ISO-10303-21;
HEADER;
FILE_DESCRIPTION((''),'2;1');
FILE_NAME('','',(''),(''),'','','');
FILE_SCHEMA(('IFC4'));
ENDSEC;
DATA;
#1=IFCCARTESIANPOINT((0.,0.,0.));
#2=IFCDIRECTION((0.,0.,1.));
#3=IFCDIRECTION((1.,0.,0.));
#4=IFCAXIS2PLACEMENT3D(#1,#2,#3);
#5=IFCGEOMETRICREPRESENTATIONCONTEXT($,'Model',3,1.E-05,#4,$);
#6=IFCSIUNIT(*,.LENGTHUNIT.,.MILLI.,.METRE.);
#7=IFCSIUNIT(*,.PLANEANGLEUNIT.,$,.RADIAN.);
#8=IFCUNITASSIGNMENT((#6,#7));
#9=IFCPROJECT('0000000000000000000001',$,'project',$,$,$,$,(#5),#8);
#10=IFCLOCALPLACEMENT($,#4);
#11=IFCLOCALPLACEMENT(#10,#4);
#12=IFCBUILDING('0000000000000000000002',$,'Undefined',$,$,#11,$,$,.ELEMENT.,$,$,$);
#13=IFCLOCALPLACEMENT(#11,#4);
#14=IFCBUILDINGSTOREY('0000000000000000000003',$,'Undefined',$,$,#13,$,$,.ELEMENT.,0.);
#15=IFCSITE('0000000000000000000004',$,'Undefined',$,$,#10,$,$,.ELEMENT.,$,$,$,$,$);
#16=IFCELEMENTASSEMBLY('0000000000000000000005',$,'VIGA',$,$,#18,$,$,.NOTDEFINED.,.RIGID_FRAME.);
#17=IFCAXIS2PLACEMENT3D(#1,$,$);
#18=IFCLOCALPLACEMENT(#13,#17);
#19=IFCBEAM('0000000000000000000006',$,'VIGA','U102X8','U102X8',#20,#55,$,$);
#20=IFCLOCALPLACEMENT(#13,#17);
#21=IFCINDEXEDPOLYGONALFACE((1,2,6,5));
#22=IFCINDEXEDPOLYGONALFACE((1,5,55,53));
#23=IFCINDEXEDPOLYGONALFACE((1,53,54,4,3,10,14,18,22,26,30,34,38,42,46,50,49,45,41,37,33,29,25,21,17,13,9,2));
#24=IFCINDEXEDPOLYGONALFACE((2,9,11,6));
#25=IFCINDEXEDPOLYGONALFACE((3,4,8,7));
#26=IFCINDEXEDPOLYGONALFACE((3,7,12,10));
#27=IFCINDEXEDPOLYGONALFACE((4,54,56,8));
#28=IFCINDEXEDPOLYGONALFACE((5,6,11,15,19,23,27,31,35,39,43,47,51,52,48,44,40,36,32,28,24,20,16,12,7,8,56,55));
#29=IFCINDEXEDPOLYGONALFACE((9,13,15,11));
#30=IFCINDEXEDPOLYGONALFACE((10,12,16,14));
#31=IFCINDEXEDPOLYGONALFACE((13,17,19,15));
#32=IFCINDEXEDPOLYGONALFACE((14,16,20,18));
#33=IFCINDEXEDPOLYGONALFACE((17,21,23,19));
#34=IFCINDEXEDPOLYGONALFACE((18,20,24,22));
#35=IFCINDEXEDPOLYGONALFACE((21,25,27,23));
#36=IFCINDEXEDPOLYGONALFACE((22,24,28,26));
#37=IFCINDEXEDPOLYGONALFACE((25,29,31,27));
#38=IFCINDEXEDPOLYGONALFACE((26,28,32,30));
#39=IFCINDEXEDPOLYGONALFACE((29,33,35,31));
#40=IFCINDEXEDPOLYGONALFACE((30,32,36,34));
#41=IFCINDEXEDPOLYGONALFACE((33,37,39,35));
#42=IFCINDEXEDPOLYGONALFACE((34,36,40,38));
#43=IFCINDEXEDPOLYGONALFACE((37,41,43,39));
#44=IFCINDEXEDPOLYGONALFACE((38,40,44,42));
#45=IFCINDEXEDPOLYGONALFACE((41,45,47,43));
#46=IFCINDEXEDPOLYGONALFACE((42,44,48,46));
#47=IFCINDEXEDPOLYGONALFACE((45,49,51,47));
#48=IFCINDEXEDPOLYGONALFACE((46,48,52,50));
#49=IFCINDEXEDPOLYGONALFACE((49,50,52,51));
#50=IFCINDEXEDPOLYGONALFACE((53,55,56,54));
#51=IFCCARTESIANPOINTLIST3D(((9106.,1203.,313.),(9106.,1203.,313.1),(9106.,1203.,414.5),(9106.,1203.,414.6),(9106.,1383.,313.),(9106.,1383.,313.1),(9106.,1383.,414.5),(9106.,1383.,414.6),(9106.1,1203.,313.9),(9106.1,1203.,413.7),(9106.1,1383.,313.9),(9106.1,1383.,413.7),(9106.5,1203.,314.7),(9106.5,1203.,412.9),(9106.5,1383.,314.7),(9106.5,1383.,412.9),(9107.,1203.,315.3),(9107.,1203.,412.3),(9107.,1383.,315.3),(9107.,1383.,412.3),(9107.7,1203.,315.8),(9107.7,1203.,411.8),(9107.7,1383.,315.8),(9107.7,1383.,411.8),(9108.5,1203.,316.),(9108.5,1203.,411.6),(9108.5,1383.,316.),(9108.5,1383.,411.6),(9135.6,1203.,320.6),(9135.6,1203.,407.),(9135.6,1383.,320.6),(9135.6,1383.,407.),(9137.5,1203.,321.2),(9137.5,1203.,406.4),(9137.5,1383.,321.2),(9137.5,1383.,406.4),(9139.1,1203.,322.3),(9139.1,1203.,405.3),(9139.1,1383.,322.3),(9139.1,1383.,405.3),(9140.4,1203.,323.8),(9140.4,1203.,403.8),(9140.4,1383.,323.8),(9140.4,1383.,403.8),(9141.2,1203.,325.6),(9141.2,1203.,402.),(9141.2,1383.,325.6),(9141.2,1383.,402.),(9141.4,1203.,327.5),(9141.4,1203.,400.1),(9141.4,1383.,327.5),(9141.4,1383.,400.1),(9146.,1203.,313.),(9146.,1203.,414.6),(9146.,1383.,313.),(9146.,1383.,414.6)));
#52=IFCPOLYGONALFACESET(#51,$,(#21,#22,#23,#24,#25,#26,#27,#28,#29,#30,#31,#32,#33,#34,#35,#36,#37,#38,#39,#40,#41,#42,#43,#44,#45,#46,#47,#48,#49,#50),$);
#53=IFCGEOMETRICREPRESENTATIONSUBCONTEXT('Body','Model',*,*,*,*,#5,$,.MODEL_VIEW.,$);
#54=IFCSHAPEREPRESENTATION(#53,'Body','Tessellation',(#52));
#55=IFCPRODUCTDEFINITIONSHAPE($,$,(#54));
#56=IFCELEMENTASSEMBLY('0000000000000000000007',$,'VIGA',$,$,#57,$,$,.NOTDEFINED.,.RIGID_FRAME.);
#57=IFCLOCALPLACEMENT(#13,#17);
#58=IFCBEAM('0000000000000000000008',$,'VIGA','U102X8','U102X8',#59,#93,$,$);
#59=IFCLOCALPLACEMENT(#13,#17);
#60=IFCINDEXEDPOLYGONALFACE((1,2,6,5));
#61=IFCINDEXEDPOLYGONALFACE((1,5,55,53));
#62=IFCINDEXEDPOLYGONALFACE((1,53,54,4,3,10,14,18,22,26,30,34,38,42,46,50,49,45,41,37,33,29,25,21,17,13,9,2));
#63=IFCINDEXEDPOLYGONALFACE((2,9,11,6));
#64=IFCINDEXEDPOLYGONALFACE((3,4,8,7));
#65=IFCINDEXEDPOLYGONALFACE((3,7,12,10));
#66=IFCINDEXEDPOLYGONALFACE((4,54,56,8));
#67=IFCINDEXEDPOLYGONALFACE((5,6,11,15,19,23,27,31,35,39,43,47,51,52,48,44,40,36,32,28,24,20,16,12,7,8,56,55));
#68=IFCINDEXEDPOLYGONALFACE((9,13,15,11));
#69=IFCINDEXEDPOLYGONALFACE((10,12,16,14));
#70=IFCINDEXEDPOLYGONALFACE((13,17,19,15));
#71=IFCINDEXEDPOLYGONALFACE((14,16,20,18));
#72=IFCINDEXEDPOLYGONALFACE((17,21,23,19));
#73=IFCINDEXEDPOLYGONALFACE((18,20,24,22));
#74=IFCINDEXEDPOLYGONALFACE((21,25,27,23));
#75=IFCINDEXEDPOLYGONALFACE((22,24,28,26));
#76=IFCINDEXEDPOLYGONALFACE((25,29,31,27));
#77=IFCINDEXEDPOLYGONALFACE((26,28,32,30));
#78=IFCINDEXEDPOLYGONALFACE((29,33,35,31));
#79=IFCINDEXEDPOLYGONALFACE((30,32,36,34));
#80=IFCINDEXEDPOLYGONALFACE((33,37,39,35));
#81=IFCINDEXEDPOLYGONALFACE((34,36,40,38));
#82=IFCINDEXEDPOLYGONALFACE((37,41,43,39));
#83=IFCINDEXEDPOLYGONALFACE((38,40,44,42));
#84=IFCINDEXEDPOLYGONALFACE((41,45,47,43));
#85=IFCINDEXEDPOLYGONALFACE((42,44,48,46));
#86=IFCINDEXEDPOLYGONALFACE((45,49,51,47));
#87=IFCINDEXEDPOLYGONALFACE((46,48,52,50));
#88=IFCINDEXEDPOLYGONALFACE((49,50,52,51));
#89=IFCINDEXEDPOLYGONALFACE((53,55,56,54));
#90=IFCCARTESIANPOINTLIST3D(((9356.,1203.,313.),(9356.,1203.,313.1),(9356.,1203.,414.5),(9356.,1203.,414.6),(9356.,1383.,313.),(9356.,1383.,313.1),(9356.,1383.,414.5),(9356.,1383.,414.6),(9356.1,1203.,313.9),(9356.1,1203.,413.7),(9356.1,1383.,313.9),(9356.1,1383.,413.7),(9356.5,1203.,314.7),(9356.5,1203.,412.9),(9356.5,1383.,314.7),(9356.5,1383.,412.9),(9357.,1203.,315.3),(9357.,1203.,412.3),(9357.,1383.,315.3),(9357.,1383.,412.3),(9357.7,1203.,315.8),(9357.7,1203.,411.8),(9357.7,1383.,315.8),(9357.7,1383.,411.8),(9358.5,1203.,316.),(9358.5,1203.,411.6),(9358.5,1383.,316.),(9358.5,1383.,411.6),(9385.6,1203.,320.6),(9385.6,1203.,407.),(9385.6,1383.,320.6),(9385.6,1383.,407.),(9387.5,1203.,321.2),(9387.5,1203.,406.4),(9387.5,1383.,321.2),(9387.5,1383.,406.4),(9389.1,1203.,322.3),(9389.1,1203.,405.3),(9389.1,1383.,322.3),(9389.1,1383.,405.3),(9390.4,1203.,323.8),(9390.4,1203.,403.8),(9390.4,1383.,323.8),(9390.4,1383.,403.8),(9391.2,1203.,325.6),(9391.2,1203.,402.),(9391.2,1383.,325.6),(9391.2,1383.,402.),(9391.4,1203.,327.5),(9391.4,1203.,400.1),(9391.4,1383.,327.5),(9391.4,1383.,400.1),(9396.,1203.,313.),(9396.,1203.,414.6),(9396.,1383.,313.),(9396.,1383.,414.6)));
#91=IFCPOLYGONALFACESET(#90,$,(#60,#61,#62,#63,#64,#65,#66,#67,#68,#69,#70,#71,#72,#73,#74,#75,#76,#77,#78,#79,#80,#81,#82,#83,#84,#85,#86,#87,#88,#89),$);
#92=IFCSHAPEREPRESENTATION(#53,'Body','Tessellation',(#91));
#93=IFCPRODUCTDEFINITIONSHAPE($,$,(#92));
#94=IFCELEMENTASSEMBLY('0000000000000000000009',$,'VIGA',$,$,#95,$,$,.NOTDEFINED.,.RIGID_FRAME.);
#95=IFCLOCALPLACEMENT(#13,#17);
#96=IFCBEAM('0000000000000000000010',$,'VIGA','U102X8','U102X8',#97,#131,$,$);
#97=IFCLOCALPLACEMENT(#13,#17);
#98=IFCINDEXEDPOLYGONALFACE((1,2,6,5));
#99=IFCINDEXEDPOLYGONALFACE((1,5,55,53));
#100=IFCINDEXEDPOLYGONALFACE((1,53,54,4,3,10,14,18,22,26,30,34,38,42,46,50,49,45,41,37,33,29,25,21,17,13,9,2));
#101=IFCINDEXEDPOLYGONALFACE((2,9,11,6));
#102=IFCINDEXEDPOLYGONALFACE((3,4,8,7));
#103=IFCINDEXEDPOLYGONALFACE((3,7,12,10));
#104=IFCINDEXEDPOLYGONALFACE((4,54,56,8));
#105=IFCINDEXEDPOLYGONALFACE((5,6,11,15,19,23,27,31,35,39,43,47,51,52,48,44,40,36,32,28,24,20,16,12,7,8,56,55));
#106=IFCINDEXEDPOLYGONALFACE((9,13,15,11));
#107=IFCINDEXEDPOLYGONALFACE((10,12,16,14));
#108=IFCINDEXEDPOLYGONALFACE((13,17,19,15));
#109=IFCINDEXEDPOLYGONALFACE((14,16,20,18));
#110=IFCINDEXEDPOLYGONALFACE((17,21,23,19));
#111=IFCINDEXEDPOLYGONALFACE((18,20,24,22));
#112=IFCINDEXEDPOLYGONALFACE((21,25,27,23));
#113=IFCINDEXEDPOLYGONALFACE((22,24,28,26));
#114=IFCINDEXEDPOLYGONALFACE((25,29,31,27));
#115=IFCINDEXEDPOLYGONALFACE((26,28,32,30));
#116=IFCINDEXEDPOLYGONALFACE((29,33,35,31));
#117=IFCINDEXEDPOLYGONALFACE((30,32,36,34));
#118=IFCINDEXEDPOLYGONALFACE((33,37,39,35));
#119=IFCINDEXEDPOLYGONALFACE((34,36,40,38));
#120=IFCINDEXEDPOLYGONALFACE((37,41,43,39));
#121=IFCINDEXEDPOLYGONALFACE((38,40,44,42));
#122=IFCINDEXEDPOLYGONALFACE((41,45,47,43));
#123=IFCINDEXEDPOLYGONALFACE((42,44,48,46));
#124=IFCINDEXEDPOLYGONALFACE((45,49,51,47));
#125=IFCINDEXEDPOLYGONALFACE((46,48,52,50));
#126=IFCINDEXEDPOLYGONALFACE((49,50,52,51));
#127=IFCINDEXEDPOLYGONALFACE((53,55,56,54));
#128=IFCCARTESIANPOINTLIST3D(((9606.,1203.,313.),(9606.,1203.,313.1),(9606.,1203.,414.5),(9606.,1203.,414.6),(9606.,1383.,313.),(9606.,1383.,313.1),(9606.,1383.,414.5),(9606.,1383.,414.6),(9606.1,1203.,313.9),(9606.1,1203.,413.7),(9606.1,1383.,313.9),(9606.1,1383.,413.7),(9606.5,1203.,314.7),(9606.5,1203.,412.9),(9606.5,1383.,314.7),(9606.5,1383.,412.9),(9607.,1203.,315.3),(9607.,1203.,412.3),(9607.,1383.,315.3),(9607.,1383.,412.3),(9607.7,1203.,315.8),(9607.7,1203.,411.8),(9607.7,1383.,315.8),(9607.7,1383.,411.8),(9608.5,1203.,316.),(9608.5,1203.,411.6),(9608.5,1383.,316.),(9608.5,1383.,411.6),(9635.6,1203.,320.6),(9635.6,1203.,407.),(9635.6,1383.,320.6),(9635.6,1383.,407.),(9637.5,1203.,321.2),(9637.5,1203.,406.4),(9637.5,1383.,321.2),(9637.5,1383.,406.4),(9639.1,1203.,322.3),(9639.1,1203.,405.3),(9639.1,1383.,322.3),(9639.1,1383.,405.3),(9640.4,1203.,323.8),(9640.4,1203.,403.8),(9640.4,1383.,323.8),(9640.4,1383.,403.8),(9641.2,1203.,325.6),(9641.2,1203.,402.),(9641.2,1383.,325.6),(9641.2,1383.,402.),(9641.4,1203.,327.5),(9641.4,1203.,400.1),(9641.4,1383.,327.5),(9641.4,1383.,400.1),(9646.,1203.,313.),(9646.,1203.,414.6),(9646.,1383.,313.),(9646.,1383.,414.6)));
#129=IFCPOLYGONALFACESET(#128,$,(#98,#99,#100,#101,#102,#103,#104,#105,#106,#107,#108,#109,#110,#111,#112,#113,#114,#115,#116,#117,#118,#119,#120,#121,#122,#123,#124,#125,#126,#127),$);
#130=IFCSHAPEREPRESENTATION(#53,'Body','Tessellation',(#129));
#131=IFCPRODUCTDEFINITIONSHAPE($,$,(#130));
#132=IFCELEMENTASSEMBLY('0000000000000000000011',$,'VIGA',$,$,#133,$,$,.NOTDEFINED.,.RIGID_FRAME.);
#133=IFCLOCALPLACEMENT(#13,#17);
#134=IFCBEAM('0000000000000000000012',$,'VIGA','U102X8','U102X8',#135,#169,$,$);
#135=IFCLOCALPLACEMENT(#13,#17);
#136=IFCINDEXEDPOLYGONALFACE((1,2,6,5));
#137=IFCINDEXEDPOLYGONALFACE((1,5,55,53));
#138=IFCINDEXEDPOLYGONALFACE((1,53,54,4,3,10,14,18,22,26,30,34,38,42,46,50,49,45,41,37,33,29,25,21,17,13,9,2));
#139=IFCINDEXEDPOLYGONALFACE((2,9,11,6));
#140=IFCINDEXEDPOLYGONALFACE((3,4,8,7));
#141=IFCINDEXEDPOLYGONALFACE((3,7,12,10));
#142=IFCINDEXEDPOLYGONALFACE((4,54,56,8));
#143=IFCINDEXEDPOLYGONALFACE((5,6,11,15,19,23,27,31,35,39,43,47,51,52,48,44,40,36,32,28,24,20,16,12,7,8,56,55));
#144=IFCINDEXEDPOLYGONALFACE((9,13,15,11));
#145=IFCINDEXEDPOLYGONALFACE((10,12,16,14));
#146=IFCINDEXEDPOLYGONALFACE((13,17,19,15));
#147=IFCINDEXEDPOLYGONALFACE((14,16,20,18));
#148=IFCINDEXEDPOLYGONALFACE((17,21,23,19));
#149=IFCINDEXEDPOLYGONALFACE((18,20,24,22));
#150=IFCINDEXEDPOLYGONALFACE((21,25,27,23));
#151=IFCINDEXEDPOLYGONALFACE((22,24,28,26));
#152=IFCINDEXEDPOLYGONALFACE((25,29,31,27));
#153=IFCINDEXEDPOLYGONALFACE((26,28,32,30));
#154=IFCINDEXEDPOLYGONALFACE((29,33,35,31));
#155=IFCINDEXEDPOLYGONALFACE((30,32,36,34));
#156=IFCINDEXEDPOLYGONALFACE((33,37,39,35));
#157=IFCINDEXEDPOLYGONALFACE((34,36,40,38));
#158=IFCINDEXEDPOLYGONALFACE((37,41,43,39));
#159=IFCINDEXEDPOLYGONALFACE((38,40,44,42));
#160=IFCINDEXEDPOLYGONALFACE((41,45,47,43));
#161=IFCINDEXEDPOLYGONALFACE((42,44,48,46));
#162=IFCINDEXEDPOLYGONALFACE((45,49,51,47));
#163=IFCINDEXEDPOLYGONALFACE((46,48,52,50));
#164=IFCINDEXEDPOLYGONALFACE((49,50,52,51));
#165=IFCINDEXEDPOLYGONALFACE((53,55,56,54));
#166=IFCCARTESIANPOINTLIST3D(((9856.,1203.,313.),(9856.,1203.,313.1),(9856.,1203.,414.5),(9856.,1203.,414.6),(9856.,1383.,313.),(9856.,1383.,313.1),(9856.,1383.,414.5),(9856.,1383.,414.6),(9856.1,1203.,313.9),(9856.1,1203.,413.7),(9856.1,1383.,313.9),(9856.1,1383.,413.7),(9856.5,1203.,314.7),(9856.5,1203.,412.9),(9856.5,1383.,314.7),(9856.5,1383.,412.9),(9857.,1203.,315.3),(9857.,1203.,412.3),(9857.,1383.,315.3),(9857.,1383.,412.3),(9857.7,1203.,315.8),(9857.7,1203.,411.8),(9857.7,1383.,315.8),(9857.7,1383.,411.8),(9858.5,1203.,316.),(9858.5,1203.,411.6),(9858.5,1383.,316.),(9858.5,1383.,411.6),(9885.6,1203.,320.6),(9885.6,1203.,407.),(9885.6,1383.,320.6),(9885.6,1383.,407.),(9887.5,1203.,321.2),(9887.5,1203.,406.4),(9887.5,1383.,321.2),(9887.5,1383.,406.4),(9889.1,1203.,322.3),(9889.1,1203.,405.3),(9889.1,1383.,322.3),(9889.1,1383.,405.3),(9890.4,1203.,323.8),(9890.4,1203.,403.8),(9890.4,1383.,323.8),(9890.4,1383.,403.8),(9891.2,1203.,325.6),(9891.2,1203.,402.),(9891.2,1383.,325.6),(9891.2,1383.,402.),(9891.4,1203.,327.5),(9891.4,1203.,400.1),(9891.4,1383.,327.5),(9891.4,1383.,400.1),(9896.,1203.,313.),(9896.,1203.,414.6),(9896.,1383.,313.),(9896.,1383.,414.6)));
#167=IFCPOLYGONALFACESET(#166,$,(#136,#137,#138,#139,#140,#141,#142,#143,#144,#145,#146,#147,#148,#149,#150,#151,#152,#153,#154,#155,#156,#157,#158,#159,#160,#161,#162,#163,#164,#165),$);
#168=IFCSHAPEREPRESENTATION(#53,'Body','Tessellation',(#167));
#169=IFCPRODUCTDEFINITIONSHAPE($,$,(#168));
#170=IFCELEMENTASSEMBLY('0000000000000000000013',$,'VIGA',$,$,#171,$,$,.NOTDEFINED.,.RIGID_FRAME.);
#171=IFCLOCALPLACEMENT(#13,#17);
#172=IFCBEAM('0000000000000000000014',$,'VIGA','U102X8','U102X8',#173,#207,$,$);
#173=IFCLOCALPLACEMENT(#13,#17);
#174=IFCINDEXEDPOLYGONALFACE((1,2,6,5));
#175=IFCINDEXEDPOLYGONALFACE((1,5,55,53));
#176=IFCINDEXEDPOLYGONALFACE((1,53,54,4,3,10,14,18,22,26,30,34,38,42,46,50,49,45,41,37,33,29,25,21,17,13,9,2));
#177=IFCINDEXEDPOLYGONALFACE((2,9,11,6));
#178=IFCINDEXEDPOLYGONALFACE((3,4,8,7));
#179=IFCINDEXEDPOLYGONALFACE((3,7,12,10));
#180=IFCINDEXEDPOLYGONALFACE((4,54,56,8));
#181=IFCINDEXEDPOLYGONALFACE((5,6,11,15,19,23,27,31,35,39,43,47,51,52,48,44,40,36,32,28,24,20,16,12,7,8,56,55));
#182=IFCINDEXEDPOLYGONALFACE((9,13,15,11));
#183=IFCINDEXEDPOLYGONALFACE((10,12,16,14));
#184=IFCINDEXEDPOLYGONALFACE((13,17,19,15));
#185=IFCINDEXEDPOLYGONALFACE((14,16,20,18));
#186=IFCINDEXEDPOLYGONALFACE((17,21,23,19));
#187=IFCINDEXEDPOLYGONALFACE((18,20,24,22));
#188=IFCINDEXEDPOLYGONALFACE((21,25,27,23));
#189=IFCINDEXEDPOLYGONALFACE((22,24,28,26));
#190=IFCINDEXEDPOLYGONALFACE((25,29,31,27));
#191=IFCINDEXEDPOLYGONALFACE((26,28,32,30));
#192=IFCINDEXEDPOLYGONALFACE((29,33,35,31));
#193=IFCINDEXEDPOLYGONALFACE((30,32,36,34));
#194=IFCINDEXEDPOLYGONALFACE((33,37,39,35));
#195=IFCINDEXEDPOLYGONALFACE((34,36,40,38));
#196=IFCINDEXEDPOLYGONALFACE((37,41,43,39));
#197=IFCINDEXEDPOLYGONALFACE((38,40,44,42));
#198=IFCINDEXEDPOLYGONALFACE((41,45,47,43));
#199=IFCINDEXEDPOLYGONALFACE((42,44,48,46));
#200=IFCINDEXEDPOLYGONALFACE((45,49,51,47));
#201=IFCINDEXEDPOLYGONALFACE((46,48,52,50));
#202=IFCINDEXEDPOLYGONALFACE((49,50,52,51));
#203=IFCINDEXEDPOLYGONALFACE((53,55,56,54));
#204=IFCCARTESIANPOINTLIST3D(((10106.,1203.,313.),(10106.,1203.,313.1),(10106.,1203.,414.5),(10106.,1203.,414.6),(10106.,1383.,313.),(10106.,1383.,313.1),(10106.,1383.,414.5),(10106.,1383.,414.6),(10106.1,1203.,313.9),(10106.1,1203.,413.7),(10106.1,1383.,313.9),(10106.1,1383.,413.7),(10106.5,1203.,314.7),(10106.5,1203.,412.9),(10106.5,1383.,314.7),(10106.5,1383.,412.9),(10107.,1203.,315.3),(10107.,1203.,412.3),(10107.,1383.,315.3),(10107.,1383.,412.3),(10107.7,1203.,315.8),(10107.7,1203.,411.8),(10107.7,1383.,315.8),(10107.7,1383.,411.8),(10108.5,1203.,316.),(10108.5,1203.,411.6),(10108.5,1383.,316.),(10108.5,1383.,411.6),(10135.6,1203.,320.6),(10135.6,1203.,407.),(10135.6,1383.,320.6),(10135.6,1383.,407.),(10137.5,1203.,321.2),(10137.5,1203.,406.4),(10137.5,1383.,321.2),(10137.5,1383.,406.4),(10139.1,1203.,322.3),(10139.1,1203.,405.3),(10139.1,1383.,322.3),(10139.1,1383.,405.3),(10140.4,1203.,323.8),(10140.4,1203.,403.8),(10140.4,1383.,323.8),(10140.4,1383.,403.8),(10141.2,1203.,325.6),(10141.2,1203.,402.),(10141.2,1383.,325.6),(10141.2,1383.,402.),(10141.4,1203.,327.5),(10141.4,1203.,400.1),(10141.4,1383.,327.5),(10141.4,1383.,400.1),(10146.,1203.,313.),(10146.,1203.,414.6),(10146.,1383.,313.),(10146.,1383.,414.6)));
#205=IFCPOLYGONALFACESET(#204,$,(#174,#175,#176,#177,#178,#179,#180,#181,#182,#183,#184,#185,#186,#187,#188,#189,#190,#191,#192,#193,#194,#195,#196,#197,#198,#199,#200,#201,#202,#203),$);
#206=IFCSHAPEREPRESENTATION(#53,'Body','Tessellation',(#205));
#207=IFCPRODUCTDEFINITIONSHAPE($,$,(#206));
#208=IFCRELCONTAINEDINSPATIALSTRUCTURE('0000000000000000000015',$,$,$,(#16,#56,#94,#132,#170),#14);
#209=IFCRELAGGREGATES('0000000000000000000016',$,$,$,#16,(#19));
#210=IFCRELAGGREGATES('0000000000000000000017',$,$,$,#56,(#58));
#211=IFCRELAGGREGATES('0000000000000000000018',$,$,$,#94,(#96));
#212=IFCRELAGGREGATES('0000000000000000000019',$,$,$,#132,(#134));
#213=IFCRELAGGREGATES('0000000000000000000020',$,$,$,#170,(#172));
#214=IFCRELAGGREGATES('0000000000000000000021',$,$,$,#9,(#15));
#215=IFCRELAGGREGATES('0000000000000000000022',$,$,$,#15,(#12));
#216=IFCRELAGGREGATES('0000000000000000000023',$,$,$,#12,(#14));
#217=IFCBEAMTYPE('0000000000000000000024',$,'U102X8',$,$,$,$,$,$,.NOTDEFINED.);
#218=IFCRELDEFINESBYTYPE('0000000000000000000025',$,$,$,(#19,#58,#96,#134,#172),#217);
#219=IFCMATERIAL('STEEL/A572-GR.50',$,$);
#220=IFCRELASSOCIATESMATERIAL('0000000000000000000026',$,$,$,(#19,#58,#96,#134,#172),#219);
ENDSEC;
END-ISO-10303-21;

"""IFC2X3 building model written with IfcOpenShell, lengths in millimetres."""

from ifc_helpers import new_model, si_unit, frame, origin_with_axes, origin_2d_with_axis, place, context, subcontext, project, spatial, u_section, extrude, material, type_object, element, aggregate, save


model = new_model("IFC2X3")

# Units and contexts
model_context = context("Model", 3, precision=1e-05, world=origin_with_axes())
body_context = subcontext(model_context, "Body", "Model", "MODEL_VIEW")
ifc_project = project(units=[si_unit("LENGTHUNIT", "METRE", prefix="MILLI"), si_unit("PLANEANGLEUNIT", "RADIAN")], contexts=[model_context])

# Site, building, storey
site_placement = place(None, origin_with_axes())
site = spatial("IfcSite", under=ifc_project, at=site_placement, Name="Undefined", CompositionType="ELEMENT")
building_placement = place(site_placement, origin_with_axes())
building = spatial("IfcBuilding", under=site, at=building_placement, Name="Undefined", CompositionType="ELEMENT")
storey_placement = place(building_placement, origin_with_axes())
storey = spatial("IfcBuildingStorey", under=building, at=storey_placement, Name="Undefined", CompositionType="ELEMENT", Elevation=0.0)

# Element assemblies, beams
assembly_1_placement = place(storey_placement, origin_with_axes())
assembly_1 = element("IfcElementAssembly", 1, at=assembly_1_placement, inside=storey, Name="VIGA", AssemblyPlace="NOTDEFINED", PredefinedType="RIGID_FRAME")
ifc_material_1 = material(Name="STEEL/A572-GR.50")
beam_type = type_object("IfcBeamType", Name="U102X8", PredefinedType="NOTDEFINED")
beam_1_placement = place(assembly_1_placement, frame((9126.0, 1383.0, 363.8), z_axis=(0.0, 0.0, 1.0), x_axis=(0.0, -1.0, 0.0)))
beam_1 = element("IfcBeam", 2, at=beam_1_placement, type_object=beam_type, material=ifc_material_1, Name="VIGA", Description="U102X8", ObjectType="U102X8", context=body_context, shape_type="SweptSolid", body=[
    extrude(u_section(Depth=101.6, FlangeWidth=40.0, WebThickness=4.6, FlangeThickness=6.0, FilletRadius=7.0, EdgeRadius=3.0, FlangeSlope=0.16839, at=origin_2d_with_axis()), frame((180.0, 0.0, 0.0), z_axis=(-1.0, 0.0, 0.0), x_axis=(0.0, -1.0, 0.0)), (0.0, 0.0, 1.0), 180.0),
])
aggregate(assembly_1, [beam_1])
assembly_2_placement = place(storey_placement, origin_with_axes())
assembly_2 = element("IfcElementAssembly", 3, at=assembly_2_placement, inside=storey, Name="VIGA", AssemblyPlace="NOTDEFINED", PredefinedType="RIGID_FRAME")
beam_2_placement = place(assembly_2_placement, frame((9376.0, 1383.0, 363.8), z_axis=(0.0, 0.0, 1.0), x_axis=(0.0, -1.0, 0.0)))
beam_2 = element("IfcBeam", 4, at=beam_2_placement, type_object=beam_type, material=ifc_material_1, Name="VIGA", Description="U102X8", ObjectType="U102X8", context=body_context, shape_type="SweptSolid", body=[
    extrude(u_section(Depth=101.6, FlangeWidth=40.0, WebThickness=4.6, FlangeThickness=6.0, FilletRadius=7.0, EdgeRadius=3.0, FlangeSlope=0.16839, at=origin_2d_with_axis()), frame((180.0, 0.0, 0.0), z_axis=(-1.0, 0.0, 0.0), x_axis=(0.0, -1.0, 0.0)), (0.0, 0.0, 1.0), 180.0),
])
aggregate(assembly_2, [beam_2])
assembly_3_placement = place(storey_placement, origin_with_axes())
assembly_3 = element("IfcElementAssembly", 5, at=assembly_3_placement, inside=storey, Name="VIGA", AssemblyPlace="NOTDEFINED", PredefinedType="RIGID_FRAME")
beam_3_placement = place(assembly_3_placement, frame((9626.0, 1383.0, 363.8), z_axis=(0.0, 0.0, 1.0), x_axis=(0.0, -1.0, 0.0)))
beam_3 = element("IfcBeam", 6, at=beam_3_placement, type_object=beam_type, material=ifc_material_1, Name="VIGA", Description="U102X8", ObjectType="U102X8", context=body_context, shape_type="SweptSolid", body=[
    extrude(u_section(Depth=101.6, FlangeWidth=40.0, WebThickness=4.6, FlangeThickness=6.0, FilletRadius=7.0, EdgeRadius=3.0, FlangeSlope=0.16839, at=origin_2d_with_axis()), frame((180.0, 0.0, 0.0), z_axis=(-1.0, 0.0, 0.0), x_axis=(0.0, -1.0, 0.0)), (0.0, 0.0, 1.0), 180.0),
])
aggregate(assembly_3, [beam_3])
assembly_4_placement = place(storey_placement, origin_with_axes())
assembly_4 = element("IfcElementAssembly", 7, at=assembly_4_placement, inside=storey, Name="VIGA", AssemblyPlace="NOTDEFINED", PredefinedType="RIGID_FRAME")
beam_4_placement = place(assembly_4_placement, frame((9876.0, 1383.0, 363.8), z_axis=(0.0, 0.0, 1.0), x_axis=(0.0, -1.0, 0.0)))
beam_4 = element("IfcBeam", 8, at=beam_4_placement, type_object=beam_type, material=ifc_material_1, Name="VIGA", Description="U102X8", ObjectType="U102X8", context=body_context, shape_type="SweptSolid", body=[
    extrude(u_section(Depth=101.6, FlangeWidth=40.0, WebThickness=4.6, FlangeThickness=6.0, FilletRadius=7.0, EdgeRadius=3.0, FlangeSlope=0.16839, at=origin_2d_with_axis()), frame((180.0, 0.0, 0.0), z_axis=(-1.0, 0.0, 0.0), x_axis=(0.0, -1.0, 0.0)), (0.0, 0.0, 1.0), 180.0),
])
aggregate(assembly_4, [beam_4])
assembly_5_placement = place(storey_placement, origin_with_axes())
assembly_5 = element("IfcElementAssembly", 9, at=assembly_5_placement, inside=storey, Name="VIGA", AssemblyPlace="NOTDEFINED", PredefinedType="RIGID_FRAME")
beam_5_placement = place(assembly_5_placement, frame((10126.0, 1383.0, 363.8), z_axis=(0.0, 0.0, 1.0), x_axis=(0.0, -1.0, 0.0)))
beam_5 = element("IfcBeam", 10, at=beam_5_placement, type_object=beam_type, material=ifc_material_1, Name="VIGA", Description="U102X8", ObjectType="U102X8", context=body_context, shape_type="SweptSolid", body=[
    extrude(u_section(Depth=101.6, FlangeWidth=40.0, WebThickness=4.6, FlangeThickness=6.0, FilletRadius=7.0, EdgeRadius=3.0, FlangeSlope=0.16839, at=origin_2d_with_axis()), frame((180.0, 0.0, 0.0), z_axis=(-1.0, 0.0, 0.0), x_axis=(0.0, -1.0, 0.0)), (0.0, 0.0, 1.0), 180.0),
])
aggregate(assembly_5, [beam_5])

save(model, "model.ifc")
